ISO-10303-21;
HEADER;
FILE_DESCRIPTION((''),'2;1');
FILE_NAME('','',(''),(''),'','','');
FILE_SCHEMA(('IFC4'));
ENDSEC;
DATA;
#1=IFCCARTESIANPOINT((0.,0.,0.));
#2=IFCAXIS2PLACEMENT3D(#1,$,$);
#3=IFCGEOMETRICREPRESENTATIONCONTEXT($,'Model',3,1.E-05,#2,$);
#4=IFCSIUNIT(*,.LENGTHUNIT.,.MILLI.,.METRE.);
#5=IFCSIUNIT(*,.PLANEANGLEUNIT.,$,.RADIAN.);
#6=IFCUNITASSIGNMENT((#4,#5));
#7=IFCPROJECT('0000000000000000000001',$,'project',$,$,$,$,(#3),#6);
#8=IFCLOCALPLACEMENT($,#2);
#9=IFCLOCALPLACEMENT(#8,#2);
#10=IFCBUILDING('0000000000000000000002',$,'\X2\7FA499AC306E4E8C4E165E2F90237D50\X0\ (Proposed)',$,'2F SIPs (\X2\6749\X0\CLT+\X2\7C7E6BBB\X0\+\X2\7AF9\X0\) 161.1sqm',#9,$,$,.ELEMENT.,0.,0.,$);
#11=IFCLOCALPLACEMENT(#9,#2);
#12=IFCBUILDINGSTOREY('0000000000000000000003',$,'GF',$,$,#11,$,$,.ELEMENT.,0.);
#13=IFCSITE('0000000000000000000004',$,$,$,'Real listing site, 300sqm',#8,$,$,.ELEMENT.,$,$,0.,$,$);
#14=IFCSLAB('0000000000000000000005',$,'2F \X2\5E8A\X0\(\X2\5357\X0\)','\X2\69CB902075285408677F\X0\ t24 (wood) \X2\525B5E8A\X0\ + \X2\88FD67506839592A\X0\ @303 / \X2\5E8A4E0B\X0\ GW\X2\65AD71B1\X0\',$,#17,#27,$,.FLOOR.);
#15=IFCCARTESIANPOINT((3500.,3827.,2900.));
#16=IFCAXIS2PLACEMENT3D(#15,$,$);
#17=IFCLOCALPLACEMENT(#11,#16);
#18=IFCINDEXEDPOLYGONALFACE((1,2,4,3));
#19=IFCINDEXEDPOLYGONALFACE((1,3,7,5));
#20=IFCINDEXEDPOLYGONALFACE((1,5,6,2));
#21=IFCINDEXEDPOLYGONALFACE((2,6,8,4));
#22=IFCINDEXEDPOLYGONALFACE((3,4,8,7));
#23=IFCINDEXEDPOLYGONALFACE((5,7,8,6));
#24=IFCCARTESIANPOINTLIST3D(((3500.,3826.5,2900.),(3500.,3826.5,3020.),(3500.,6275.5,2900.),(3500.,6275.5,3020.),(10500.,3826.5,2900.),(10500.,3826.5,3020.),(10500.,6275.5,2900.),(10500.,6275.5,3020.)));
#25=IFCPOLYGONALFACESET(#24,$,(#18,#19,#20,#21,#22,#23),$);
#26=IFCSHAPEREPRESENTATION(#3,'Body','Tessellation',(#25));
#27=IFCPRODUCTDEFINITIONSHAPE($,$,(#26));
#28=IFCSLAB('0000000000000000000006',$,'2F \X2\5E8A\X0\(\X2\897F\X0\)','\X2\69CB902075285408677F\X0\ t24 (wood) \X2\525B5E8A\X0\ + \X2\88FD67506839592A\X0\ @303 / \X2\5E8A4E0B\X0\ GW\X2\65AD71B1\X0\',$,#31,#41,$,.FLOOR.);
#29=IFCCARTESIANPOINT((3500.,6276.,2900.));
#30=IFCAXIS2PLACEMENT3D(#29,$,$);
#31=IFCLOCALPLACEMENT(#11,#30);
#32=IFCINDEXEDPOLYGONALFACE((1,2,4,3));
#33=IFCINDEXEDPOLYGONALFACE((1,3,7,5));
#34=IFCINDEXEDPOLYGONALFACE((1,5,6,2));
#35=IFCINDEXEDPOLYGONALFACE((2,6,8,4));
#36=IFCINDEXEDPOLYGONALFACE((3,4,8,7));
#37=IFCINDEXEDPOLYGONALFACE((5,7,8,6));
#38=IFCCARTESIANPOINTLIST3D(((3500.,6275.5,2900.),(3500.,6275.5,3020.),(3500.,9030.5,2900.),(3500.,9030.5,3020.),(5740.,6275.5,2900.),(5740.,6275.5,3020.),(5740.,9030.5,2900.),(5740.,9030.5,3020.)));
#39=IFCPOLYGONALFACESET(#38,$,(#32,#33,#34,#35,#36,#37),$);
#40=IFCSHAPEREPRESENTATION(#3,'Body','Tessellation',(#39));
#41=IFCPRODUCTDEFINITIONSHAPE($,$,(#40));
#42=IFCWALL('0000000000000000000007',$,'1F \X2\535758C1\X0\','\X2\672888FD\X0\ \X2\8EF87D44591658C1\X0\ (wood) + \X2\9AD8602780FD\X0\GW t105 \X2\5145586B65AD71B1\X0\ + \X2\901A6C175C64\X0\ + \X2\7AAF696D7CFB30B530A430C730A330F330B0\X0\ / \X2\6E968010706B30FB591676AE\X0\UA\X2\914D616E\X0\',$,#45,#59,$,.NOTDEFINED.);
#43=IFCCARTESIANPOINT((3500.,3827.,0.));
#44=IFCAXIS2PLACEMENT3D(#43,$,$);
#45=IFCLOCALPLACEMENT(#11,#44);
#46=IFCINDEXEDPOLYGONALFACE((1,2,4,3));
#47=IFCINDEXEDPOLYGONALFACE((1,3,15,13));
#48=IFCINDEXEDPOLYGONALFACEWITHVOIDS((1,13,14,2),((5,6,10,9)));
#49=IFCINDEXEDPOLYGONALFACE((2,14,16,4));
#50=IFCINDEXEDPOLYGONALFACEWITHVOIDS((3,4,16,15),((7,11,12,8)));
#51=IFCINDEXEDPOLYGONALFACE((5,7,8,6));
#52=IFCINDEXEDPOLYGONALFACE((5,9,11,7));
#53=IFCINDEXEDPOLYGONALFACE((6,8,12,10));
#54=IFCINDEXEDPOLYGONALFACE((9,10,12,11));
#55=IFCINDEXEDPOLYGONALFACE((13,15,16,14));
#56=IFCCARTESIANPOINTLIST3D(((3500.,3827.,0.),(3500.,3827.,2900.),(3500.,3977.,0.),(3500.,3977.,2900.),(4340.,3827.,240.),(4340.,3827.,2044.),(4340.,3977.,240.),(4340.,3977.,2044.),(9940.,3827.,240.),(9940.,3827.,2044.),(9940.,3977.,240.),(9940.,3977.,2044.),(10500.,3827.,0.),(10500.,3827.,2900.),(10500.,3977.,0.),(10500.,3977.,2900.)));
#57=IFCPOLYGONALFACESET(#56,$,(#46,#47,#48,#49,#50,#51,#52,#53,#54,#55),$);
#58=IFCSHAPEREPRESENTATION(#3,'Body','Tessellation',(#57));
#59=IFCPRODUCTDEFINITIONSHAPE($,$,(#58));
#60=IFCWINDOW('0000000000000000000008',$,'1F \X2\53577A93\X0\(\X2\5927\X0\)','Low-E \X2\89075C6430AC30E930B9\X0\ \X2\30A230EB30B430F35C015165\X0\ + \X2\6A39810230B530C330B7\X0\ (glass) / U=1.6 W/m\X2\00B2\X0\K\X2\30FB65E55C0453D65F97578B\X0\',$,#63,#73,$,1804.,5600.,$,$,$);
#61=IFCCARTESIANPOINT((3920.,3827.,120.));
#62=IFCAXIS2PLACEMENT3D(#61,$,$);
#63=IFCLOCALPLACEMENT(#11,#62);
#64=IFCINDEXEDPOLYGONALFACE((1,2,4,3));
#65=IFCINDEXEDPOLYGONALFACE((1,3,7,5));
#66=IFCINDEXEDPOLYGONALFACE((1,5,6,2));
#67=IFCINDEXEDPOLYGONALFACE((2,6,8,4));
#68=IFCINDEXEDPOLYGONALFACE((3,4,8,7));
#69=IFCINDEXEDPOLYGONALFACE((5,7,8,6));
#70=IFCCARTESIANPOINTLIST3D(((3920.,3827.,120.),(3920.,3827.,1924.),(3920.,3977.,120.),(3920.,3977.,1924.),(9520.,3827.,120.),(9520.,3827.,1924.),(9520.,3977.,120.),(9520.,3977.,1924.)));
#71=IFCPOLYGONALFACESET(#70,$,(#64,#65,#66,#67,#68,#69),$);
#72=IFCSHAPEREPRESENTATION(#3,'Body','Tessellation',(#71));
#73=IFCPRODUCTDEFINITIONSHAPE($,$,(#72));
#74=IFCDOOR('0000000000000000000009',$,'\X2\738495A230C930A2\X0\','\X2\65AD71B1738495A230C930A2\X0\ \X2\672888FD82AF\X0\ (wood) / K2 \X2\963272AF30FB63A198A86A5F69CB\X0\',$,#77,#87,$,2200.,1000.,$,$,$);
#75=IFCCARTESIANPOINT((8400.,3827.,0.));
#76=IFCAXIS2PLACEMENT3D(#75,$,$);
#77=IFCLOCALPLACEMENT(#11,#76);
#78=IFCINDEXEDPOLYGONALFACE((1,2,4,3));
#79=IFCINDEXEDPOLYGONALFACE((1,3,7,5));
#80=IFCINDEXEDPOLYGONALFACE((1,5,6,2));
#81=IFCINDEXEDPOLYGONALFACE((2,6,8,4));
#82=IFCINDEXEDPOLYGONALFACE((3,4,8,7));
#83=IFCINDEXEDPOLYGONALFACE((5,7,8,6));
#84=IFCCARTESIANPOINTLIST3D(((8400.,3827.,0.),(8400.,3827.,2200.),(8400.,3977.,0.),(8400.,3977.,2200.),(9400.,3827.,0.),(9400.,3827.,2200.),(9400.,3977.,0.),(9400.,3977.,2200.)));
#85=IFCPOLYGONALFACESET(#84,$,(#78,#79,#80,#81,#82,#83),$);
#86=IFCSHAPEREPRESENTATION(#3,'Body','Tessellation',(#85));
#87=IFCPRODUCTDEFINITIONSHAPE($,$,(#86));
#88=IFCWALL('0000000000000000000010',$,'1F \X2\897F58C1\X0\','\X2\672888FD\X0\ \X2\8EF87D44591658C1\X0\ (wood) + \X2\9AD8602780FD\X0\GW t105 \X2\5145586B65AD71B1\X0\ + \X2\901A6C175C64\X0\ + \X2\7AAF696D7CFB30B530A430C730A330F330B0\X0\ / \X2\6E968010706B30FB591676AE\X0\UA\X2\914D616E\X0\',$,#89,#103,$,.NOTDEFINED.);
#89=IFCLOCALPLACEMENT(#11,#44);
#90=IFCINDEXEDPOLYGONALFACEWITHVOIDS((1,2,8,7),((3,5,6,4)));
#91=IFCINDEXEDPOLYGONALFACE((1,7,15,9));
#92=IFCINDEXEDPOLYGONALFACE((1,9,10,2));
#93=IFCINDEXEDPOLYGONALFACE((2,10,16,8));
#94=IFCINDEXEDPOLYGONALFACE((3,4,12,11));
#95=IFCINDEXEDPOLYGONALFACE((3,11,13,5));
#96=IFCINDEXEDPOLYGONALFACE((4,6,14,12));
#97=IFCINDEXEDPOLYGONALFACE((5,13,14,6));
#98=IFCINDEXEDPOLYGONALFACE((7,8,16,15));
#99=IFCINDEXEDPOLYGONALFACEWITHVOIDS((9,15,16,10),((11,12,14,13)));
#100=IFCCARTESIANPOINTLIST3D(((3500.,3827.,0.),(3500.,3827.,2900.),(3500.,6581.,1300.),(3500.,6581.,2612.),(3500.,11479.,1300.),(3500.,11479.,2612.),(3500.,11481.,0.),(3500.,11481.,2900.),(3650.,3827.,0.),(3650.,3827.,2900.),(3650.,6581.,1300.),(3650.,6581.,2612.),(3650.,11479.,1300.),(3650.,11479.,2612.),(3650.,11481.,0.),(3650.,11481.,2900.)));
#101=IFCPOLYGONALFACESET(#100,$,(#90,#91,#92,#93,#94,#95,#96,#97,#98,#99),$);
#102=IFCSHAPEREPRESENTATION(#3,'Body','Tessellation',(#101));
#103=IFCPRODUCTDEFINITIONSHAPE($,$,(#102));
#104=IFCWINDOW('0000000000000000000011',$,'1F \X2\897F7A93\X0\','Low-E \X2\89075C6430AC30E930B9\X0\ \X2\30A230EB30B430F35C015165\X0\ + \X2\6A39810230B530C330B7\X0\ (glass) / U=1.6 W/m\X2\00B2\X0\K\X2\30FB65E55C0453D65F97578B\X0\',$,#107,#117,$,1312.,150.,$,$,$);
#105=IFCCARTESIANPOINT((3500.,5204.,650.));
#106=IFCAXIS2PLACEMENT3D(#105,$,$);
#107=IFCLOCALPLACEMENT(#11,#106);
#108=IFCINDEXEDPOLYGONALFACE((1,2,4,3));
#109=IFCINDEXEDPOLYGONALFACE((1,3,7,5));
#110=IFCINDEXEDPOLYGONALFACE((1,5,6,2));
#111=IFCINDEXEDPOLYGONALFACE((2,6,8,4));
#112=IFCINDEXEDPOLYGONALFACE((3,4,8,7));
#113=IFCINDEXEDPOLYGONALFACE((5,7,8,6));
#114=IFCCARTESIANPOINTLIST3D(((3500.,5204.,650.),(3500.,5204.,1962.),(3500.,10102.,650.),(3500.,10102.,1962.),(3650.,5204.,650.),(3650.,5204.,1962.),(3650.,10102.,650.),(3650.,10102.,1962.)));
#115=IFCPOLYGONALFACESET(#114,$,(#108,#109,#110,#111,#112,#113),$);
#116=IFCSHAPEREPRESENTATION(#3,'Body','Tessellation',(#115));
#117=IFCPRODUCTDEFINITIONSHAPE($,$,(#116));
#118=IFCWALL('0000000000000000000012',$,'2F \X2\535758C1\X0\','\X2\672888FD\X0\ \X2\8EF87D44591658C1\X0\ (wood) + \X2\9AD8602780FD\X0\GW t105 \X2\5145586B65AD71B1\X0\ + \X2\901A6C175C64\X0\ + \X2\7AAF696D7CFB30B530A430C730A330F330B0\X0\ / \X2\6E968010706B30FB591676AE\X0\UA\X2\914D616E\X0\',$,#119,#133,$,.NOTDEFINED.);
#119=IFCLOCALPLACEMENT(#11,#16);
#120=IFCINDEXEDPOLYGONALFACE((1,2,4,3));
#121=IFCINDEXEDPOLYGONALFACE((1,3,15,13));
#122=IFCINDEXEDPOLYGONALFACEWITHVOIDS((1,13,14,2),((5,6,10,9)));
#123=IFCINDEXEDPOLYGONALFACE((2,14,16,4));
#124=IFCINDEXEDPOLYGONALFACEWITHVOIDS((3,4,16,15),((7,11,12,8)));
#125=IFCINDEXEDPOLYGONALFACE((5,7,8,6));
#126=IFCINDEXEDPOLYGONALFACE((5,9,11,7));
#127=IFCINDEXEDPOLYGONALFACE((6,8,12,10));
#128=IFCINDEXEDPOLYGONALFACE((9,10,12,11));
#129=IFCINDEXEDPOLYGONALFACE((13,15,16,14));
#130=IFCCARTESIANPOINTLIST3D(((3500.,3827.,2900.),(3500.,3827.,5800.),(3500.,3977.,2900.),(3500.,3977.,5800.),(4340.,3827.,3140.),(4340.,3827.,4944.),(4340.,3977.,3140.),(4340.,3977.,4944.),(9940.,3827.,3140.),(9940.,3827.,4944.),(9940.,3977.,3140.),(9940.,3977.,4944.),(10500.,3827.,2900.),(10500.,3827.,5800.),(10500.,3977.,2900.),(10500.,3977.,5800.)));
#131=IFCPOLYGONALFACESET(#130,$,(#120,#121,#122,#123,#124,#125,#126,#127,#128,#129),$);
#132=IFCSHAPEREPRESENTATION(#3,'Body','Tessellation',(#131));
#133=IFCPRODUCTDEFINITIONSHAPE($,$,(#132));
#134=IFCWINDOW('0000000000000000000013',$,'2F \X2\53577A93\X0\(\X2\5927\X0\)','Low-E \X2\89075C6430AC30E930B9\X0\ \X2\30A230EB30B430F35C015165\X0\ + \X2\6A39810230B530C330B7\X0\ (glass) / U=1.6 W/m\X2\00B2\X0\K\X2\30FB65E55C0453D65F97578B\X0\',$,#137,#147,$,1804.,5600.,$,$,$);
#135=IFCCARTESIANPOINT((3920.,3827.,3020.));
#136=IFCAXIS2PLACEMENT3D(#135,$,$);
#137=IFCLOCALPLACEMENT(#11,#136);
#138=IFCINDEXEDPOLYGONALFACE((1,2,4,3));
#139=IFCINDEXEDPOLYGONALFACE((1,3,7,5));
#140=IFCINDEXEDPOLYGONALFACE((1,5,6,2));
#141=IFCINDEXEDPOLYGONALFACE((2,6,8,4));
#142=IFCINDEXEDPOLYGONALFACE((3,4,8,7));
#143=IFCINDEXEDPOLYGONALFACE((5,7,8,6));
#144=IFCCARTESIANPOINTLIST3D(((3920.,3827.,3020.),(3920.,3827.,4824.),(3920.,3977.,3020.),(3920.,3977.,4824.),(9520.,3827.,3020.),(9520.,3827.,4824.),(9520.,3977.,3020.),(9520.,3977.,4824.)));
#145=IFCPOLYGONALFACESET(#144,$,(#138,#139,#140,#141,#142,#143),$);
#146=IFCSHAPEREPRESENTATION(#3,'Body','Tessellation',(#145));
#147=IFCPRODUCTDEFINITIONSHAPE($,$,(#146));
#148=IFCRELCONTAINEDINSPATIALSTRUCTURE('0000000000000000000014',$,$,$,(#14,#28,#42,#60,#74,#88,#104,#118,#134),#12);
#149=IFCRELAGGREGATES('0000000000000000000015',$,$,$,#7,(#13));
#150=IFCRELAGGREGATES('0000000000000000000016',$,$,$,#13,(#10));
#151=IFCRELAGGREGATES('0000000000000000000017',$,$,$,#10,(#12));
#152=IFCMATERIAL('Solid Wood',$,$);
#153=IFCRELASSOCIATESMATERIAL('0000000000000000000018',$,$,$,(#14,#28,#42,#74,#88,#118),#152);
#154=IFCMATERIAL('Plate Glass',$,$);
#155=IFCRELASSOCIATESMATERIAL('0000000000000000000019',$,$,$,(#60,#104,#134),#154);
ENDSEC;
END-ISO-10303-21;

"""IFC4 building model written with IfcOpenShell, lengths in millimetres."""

from ifc_helpers import new_model, si_unit, frame, frame_2d, origin, place, context, project, spatial, rectangle, extrude, material, element, fill, save


model = new_model("IFC4")

# Units and contexts
model_context = context("Model", 3, precision=1e-05, world=origin())
ifc_project = project(units=[si_unit("LENGTHUNIT", "METRE", prefix="MILLI"), si_unit("PLANEANGLEUNIT", "RADIAN")], contexts=[model_context])

# Site, building, storey
site_placement = place(None, origin())
site = spatial("IfcSite", under=ifc_project, at=site_placement, ObjectType="Real listing site, 300sqm", CompositionType="ELEMENT", RefElevation=0.0)
building_placement = place(site_placement, origin())
building = spatial("IfcBuilding", under=site, at=building_placement, Name="群馬の二世帯連結 (Proposed)", ObjectType="2F SIPs (杉CLT+籾殻+竹) 161.1sqm", CompositionType="ELEMENT", ElevationOfRefHeight=0.0, ElevationOfTerrain=0.0)
storey_placement = place(building_placement, origin())
storey = spatial("IfcBuildingStorey", under=building, at=storey_placement, Name="GF", CompositionType="ELEMENT", Elevation=0.0)

# Slabs
ifc_material_1 = material(Name="Solid Wood")
slab_1_placement = place(storey_placement, frame((3500.0, 3827.0, 2900.0)))
element("IfcSlab", 1, at=slab_1_placement, inside=storey, material=ifc_material_1, Name="2F 床(南)", Description="構造用合板 t24 (wood) 剛床 + 製材根太 @303 / 床下 GW断熱", PredefinedType="FLOOR", context=model_context, shape_type="SweptSolid", body=[
    extrude(rectangle(XDim=7000.0, YDim=2449.0, at=frame_2d((3500.0, 1224.0))), frame((3500.0, 3827.0, 2900.0)), (0.0, 0.0, 1.0), 120.0),
])
slab_2_placement = place(storey_placement, frame((3500.0, 6276.0, 2900.0)))
element("IfcSlab", 2, at=slab_2_placement, inside=storey, material=ifc_material_1, Name="2F 床(西)", Description="構造用合板 t24 (wood) 剛床 + 製材根太 @303 / 床下 GW断熱", PredefinedType="FLOOR", context=model_context, shape_type="SweptSolid", body=[
    extrude(rectangle(XDim=2240.0, YDim=2755.0, at=frame_2d((1120.0, 1377.0))), frame((3500.0, 6276.0, 2900.0)), (0.0, 0.0, 1.0), 120.0),
])

# Wall, openings, window, door
wall_1_placement = place(storey_placement, frame((3500.0, 3827.0, 0.0)))
wall_1 = element("IfcWall", 3, at=wall_1_placement, inside=storey, material=ifc_material_1, Name="1F 南壁", Description="木製 軸組外壁 (wood) + 高性能GW t105 充填断熱 + 通気層 + 窯業系サイディング / 準耐火・外皮UA配慮", PredefinedType="NOTDEFINED", context=model_context, shape_type="SweptSolid", body=[
    extrude(rectangle(XDim=7000.0, YDim=150.0, at=frame_2d((3500.0, 75.0))), frame((3500.0, 3827.0, 0.0)), (0.0, 0.0, 1.0), 2900.0),
])
opening_1_placement = place(storey_placement, frame((3920.0, 3827.0, 120.0)))
opening_1 = element("IfcOpeningElement", 4, at=opening_1_placement, cuts=wall_1, PredefinedType="NOTDEFINED", context=model_context, shape_type="SweptSolid", body=[
    extrude(rectangle(XDim=5600.0, YDim=150.0, at=frame_2d((2800.0, 75.0))), frame((3920.0, 3827.0, 120.0)), (0.0, 0.0, 1.0), 1804.0),
])
opening_2_placement = place(storey_placement, frame((8400.0, 3827.0, 0.0)))
opening_2 = element("IfcOpeningElement", 5, at=opening_2_placement, cuts=wall_1, PredefinedType="NOTDEFINED", context=model_context, shape_type="SweptSolid", body=[
    extrude(rectangle(XDim=1000.0, YDim=150.0, at=frame_2d((500.0, 75.0))), frame((8400.0, 3827.0, 0.0)), (0.0, 0.0, 1.0), 2200.0),
])
ifc_material_2 = material(Name="Plate Glass")
window_1_placement = place(storey_placement, frame((3920.0, 3827.0, 120.0)))
window_1 = element("IfcWindow", 6, at=window_1_placement, inside=storey, material=ifc_material_2, Name="1F 南窓(大)", Description="Low-E 複層ガラス アルゴン封入 + 樹脂サッシ (glass) / U=1.6 W/m²K・日射取得型", OverallHeight=1804.0, OverallWidth=5600.0, context=model_context, shape_type="SweptSolid", body=[
    extrude(rectangle(XDim=5600.0, YDim=150.0, at=frame_2d((2800.0, 75.0))), frame((3920.0, 3827.0, 120.0)), (0.0, 0.0, 1.0), 1804.0),
])
fill(opening_1, window_1)
door_placement = place(storey_placement, frame((8400.0, 3827.0, 0.0)))
door = element("IfcDoor", 7, at=door_placement, inside=storey, material=ifc_material_1, Name="玄関ドア", Description="断熱玄関ドア 木製芯 (wood) / K2 防犯・採風機構", OverallHeight=2200.0, OverallWidth=1000.0, context=model_context, shape_type="SweptSolid", body=[
    extrude(rectangle(XDim=1000.0, YDim=150.0, at=frame_2d((500.0, 75.0))), frame((8400.0, 3827.0, 0.0)), (0.0, 0.0, 1.0), 2200.0),
])
fill(opening_2, door)

# Walls, openings, windows
wall_2_placement = place(storey_placement, frame((3500.0, 3827.0, 0.0)))
wall_2 = element("IfcWall", 8, at=wall_2_placement, inside=storey, material=ifc_material_1, Name="1F 西壁", Description="木製 軸組外壁 (wood) + 高性能GW t105 充填断熱 + 通気層 + 窯業系サイディング / 準耐火・外皮UA配慮", PredefinedType="NOTDEFINED", context=model_context, shape_type="SweptSolid", body=[
    extrude(rectangle(XDim=150.0, YDim=7654.0, at=frame_2d((75.0, 3827.0))), frame((3500.0, 3827.0, 0.0)), (0.0, 0.0, 1.0), 2900.0),
])
opening_3_placement = place(storey_placement, frame((3500.0, 5204.0, 650.0)))
opening_3 = element("IfcOpeningElement", 9, at=opening_3_placement, cuts=wall_2, PredefinedType="NOTDEFINED", context=model_context, shape_type="SweptSolid", body=[
    extrude(rectangle(XDim=150.0, YDim=4898.0, at=frame_2d((75.0, 2449.0))), frame((3500.0, 5204.0, 650.0)), (0.0, 0.0, 1.0), 1312.0),
])
window_2_placement = place(storey_placement, frame((3500.0, 5204.0, 650.0)))
window_2 = element("IfcWindow", 10, at=window_2_placement, inside=storey, material=ifc_material_2, Name="1F 西窓", Description="Low-E 複層ガラス アルゴン封入 + 樹脂サッシ (glass) / U=1.6 W/m²K・日射取得型", OverallHeight=1312.0, OverallWidth=150.0, context=model_context, shape_type="SweptSolid", body=[
    extrude(rectangle(XDim=150.0, YDim=4898.0, at=frame_2d((75.0, 2449.0))), frame((3500.0, 5204.0, 650.0)), (0.0, 0.0, 1.0), 1312.0),
])
fill(opening_3, window_2)
wall_3_placement = place(storey_placement, frame((3500.0, 3827.0, 2900.0)))
wall_3 = element("IfcWall", 11, at=wall_3_placement, inside=storey, material=ifc_material_1, Name="2F 南壁", Description="木製 軸組外壁 (wood) + 高性能GW t105 充填断熱 + 通気層 + 窯業系サイディング / 準耐火・外皮UA配慮", PredefinedType="NOTDEFINED", context=model_context, shape_type="SweptSolid", body=[
    extrude(rectangle(XDim=7000.0, YDim=150.0, at=frame_2d((3500.0, 75.0))), frame((3500.0, 3827.0, 2900.0)), (0.0, 0.0, 1.0), 2900.0),
])
opening_4_placement = place(storey_placement, frame((3920.0, 3827.0, 3020.0)))
opening_4 = element("IfcOpeningElement", 12, at=opening_4_placement, cuts=wall_3, PredefinedType="NOTDEFINED", context=model_context, shape_type="SweptSolid", body=[
    extrude(rectangle(XDim=5600.0, YDim=150.0, at=frame_2d((2800.0, 75.0))), frame((3920.0, 3827.0, 3020.0)), (0.0, 0.0, 1.0), 1804.0),
])
window_3_placement = place(storey_placement, frame((3920.0, 3827.0, 3020.0)))
window_3 = element("IfcWindow", 13, at=window_3_placement, inside=storey, material=ifc_material_2, Name="2F 南窓(大)", Description="Low-E 複層ガラス アルゴン封入 + 樹脂サッシ (glass) / U=1.6 W/m²K・日射取得型", OverallHeight=1804.0, OverallWidth=5600.0, context=model_context, shape_type="SweptSolid", body=[
    extrude(rectangle(XDim=5600.0, YDim=150.0, at=frame_2d((2800.0, 75.0))), frame((3920.0, 3827.0, 3020.0)), (0.0, 0.0, 1.0), 1804.0),
])
fill(opening_4, window_3)

save(model, "model.ifc")
